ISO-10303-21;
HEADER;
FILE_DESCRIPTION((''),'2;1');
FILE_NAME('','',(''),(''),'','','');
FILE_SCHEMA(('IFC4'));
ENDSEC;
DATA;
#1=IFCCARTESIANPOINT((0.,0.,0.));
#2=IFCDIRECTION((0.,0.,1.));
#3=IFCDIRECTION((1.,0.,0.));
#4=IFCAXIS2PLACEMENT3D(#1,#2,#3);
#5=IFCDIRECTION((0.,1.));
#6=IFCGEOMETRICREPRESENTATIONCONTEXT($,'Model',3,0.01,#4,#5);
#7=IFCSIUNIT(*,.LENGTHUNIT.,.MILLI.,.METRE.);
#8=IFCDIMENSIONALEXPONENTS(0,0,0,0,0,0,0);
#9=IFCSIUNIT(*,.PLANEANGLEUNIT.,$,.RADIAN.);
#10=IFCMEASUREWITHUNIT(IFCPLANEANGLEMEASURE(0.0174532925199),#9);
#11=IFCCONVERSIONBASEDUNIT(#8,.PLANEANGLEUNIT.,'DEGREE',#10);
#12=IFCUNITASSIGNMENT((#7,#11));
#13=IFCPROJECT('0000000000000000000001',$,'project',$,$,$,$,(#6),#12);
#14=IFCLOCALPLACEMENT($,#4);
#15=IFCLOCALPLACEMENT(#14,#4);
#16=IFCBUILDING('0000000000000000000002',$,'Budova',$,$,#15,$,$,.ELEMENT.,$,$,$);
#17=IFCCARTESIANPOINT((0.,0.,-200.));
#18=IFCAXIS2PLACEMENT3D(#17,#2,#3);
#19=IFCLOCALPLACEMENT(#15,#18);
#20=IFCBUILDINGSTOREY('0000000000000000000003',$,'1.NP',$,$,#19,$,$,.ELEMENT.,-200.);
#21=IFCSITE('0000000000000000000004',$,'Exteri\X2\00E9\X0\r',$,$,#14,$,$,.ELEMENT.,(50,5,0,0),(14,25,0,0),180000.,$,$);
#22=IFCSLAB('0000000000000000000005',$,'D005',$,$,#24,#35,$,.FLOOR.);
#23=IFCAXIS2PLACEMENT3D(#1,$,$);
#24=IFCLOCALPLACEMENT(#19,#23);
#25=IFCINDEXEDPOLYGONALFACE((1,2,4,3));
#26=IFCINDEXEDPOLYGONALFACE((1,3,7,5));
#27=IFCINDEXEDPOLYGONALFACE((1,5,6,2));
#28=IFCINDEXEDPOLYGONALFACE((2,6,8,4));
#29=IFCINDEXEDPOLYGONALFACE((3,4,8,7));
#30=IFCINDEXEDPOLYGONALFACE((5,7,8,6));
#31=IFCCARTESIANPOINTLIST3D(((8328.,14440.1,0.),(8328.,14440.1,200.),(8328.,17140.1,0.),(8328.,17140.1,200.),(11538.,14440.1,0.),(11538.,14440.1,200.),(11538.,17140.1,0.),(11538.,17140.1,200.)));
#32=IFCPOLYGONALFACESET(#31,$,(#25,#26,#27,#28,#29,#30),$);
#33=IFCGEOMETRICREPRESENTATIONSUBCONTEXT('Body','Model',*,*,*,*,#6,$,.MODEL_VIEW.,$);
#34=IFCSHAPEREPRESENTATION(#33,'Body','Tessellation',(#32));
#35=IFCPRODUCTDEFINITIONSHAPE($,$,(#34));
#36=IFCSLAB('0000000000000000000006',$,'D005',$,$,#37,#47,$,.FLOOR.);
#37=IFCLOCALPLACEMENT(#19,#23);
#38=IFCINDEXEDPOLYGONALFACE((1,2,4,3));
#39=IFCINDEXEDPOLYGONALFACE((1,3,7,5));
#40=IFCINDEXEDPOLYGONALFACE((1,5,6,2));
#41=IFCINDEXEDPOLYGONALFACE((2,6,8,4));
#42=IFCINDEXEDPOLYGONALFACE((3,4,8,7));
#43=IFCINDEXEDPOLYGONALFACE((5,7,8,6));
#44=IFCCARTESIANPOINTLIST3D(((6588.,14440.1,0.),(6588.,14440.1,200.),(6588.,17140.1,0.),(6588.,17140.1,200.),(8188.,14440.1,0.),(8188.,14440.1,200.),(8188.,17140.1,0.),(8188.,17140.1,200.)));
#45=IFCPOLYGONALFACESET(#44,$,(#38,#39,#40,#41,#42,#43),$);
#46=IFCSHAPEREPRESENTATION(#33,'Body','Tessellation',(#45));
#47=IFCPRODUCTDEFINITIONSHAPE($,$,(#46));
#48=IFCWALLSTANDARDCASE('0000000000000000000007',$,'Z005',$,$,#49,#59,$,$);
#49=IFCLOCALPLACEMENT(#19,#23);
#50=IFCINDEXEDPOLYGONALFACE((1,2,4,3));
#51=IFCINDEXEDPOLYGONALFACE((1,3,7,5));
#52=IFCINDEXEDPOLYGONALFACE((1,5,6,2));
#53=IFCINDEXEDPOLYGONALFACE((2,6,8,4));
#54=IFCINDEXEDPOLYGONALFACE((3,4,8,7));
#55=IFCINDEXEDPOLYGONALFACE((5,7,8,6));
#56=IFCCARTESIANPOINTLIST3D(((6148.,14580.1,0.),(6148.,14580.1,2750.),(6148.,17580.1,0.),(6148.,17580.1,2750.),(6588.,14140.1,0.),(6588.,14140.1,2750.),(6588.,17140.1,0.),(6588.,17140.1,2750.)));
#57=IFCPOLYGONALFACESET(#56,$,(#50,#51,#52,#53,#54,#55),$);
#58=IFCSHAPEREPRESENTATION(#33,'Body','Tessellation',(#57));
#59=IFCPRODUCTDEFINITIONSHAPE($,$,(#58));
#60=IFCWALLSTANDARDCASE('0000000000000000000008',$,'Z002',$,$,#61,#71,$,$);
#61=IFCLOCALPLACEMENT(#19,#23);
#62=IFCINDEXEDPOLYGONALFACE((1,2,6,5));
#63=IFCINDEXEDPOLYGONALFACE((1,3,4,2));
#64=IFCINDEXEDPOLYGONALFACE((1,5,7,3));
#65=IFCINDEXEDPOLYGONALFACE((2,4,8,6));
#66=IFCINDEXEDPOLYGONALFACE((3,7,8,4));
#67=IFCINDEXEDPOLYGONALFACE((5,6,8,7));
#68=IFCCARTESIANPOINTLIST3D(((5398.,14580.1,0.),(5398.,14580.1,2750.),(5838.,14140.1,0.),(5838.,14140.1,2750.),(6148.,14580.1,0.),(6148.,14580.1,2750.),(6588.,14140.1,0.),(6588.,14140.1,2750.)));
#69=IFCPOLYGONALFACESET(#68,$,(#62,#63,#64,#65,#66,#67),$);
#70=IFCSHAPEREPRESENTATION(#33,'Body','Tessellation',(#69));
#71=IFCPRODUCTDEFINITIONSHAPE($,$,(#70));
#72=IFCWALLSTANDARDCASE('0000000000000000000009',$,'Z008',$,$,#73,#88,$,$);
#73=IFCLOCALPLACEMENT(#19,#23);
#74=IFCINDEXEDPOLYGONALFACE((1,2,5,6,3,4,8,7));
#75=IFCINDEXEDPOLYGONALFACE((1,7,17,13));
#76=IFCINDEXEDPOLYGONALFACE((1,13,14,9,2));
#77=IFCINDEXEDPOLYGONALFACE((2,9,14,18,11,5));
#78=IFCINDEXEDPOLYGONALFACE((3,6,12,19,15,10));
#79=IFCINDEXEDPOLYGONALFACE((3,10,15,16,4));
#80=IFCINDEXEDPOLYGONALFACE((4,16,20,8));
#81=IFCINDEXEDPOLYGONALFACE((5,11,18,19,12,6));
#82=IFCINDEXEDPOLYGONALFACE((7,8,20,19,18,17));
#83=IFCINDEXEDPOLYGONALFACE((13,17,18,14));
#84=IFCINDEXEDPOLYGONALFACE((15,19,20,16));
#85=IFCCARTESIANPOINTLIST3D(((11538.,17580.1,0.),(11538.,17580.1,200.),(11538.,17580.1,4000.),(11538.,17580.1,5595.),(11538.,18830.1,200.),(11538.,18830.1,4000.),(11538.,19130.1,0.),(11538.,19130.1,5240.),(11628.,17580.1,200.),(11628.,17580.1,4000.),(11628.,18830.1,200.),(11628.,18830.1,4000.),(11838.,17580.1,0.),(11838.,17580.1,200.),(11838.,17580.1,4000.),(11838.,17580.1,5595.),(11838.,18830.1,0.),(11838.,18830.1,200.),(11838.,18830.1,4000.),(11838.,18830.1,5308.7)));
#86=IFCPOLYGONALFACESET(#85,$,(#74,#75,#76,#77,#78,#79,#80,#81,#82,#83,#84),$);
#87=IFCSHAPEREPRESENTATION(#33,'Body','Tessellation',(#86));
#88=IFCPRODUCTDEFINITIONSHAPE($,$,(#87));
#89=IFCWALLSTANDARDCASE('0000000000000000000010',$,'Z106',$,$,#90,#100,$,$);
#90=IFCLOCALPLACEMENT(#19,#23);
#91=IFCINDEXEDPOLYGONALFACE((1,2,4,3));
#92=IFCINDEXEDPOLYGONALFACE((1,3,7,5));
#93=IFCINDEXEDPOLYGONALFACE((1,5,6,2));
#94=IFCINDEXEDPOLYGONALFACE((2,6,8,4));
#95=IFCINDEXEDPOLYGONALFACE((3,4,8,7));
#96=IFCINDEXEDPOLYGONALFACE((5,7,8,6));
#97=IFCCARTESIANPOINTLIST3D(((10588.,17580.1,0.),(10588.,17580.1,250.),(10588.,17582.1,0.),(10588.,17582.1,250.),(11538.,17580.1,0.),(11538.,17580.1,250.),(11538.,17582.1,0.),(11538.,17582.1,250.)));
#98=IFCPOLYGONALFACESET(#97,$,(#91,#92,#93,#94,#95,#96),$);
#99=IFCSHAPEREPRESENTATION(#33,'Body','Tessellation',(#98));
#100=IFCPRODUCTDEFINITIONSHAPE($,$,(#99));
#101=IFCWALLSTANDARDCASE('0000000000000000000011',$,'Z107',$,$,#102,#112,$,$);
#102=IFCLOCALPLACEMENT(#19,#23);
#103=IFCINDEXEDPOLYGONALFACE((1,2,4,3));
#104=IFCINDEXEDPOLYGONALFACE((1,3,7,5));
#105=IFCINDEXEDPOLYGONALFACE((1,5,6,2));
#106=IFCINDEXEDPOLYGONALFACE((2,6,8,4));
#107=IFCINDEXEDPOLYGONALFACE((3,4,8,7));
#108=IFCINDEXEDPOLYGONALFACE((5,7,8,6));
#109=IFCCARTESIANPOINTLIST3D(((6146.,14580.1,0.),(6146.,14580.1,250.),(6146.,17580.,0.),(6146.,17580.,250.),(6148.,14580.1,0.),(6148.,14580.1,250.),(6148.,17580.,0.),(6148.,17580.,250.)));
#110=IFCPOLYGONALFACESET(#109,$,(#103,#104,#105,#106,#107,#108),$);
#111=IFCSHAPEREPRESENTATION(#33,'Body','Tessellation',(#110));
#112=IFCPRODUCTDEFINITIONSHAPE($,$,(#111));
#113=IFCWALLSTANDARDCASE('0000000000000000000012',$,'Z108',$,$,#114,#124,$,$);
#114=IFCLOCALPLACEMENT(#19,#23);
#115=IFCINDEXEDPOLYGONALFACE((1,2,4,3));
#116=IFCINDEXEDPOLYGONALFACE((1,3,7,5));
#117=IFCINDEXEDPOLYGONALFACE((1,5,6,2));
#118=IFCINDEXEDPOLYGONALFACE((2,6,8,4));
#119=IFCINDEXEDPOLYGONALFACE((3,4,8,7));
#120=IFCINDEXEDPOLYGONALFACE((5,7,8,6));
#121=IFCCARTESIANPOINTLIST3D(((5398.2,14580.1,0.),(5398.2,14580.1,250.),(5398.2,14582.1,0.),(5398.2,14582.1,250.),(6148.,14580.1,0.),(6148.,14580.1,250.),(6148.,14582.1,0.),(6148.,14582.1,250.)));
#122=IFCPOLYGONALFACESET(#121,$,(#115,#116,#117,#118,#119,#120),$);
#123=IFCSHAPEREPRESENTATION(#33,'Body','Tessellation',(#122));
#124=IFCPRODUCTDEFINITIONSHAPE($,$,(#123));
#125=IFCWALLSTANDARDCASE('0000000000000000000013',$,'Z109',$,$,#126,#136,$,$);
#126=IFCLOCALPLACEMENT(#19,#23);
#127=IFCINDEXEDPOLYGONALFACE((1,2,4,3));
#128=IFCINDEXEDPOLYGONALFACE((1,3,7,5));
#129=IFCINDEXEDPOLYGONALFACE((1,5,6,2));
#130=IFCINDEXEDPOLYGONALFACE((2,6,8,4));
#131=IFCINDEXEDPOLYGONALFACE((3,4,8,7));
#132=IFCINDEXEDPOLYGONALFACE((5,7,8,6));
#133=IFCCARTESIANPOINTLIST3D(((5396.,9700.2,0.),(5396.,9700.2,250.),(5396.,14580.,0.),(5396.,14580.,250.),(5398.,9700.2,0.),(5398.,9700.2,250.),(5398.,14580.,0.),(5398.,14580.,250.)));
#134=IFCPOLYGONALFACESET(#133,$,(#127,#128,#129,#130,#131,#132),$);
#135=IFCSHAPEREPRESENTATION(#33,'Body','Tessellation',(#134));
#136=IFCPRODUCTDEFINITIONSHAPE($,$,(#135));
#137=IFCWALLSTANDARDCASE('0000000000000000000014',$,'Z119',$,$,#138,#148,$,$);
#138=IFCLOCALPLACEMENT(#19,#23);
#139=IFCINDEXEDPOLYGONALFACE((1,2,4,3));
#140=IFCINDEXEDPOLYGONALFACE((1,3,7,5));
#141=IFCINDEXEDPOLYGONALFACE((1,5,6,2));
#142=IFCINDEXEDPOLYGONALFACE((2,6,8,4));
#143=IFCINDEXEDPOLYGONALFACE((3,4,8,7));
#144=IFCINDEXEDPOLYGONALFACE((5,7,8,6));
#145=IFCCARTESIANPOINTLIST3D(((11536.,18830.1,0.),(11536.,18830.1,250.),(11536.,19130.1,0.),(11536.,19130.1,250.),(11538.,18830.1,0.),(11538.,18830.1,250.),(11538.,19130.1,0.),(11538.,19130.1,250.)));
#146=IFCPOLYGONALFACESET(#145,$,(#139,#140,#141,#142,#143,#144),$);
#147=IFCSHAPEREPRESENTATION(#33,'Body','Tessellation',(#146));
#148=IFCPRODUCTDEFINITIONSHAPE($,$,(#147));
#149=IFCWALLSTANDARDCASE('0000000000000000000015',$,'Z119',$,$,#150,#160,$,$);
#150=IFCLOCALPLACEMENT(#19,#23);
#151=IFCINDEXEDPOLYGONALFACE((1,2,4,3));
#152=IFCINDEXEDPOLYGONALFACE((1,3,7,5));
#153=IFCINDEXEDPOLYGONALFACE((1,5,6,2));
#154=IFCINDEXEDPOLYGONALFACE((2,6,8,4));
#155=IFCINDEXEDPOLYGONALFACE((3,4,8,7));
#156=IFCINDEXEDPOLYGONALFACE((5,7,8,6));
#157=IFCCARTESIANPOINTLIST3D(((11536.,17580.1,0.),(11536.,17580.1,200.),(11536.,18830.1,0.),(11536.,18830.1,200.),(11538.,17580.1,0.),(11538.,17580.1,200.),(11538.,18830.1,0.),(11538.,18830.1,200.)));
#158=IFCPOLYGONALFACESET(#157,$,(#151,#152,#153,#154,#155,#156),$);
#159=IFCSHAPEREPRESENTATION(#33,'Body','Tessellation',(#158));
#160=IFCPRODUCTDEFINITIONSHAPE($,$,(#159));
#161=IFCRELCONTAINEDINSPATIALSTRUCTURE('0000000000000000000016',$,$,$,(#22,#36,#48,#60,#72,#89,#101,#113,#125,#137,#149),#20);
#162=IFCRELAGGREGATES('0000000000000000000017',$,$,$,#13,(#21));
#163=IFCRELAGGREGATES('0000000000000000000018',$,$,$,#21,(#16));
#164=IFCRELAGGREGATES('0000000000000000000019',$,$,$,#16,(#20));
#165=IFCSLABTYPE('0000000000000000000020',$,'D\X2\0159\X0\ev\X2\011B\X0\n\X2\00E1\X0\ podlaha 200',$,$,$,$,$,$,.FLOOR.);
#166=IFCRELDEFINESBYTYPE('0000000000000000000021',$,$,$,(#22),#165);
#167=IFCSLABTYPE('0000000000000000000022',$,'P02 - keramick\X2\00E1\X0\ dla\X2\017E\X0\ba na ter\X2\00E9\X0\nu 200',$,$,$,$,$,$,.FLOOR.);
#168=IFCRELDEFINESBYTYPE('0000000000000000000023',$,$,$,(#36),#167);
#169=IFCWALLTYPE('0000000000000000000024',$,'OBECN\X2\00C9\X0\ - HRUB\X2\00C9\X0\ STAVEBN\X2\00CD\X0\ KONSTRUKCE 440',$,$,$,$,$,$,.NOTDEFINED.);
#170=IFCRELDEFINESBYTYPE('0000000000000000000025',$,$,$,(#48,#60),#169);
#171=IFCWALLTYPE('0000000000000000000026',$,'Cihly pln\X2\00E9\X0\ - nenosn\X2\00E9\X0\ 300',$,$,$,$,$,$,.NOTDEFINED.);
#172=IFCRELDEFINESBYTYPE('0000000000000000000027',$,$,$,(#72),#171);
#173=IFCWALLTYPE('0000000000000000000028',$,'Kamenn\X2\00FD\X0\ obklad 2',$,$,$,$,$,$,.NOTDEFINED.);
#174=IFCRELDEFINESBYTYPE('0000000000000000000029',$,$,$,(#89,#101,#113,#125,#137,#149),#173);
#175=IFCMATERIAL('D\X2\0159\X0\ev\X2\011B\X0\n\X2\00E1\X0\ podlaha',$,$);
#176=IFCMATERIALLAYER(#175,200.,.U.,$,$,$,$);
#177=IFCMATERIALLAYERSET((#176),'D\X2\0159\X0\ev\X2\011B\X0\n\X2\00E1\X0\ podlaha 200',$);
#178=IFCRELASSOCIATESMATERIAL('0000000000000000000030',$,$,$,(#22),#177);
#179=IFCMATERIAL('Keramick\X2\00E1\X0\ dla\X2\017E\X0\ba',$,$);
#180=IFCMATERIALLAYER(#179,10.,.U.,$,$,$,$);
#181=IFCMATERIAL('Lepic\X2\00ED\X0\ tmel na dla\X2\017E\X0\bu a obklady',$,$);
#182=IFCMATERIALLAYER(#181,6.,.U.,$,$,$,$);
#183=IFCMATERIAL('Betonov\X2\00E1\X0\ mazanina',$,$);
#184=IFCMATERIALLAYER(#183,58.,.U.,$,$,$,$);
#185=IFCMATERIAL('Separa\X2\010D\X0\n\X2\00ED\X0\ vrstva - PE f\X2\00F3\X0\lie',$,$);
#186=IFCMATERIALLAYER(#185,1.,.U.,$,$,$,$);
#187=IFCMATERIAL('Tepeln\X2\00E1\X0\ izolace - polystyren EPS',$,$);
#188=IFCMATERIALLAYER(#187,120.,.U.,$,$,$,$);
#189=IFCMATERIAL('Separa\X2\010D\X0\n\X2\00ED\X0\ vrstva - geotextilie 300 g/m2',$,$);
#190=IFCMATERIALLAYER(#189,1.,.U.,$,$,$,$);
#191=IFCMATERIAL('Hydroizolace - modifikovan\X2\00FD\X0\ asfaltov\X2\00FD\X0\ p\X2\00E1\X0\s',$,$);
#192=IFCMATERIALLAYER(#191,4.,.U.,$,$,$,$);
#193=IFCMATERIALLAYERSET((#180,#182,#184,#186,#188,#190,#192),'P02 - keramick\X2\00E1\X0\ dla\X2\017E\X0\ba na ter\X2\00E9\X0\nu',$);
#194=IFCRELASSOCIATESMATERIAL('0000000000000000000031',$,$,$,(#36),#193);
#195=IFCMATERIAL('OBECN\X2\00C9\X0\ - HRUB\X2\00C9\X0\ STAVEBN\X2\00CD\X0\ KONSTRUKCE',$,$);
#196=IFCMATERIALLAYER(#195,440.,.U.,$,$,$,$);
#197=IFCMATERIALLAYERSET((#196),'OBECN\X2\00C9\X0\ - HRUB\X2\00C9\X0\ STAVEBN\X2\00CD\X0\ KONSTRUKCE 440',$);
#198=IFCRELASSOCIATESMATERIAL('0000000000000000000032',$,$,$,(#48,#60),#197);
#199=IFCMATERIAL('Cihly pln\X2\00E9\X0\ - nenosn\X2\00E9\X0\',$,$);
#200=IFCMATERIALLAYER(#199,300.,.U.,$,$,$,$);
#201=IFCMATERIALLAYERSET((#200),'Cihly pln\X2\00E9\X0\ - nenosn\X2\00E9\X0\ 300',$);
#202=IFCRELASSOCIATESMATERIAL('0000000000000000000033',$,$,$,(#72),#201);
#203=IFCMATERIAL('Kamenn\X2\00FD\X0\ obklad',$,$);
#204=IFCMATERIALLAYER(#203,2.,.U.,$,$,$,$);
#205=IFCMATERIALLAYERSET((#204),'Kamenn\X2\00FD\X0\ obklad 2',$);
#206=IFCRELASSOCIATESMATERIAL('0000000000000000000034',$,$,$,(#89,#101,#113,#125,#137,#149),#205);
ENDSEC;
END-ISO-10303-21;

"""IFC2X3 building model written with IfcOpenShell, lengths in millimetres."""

from ifc_helpers import new_model, entity, si_unit, converted_unit, direction, frame, origin_with_axes, origin_2d_with_axis, place, context, subcontext, project, spatial, polyline, rectangle, outline, extrude, clip, halfspace, material, layer, layer_set, layer_usage, type_object, element, save


model = new_model("IFC2X3")

# Units and contexts
model_context = context("Model", 3, precision=0.01, world=origin_with_axes(), true_north=direction((0.0, 1.0)))
body_context = subcontext(model_context, "Body", "Model", "MODEL_VIEW")
ifc_project = project(units=[si_unit("LENGTHUNIT", "METRE", prefix="MILLI"), converted_unit("PLANEANGLEUNIT", "DEGREE", entity("IfcPlaneAngleMeasure", 0.0174532925199), si_unit("PLANEANGLEUNIT", "RADIAN"), dimensions=[0, 0, 0, 0, 0, 0, 0])], contexts=[model_context])

# Site, building, storey
site_placement = place(None, origin_with_axes())
site = spatial("IfcSite", under=ifc_project, at=site_placement, Name="Exteriér", CompositionType="ELEMENT", RefLatitude=(50, 5, 0, 0), RefLongitude=(14, 25, 0, 0), RefElevation=180000.0)
building_placement = place(site_placement, origin_with_axes())
building = spatial("IfcBuilding", under=site, at=building_placement, Name="Budova", CompositionType="ELEMENT")
storey_placement = place(building_placement, frame((0.0, 0.0, -200.0), z_axis=(0.0, 0.0, 1.0), x_axis=(1.0, 0.0, 0.0)))
storey = spatial("IfcBuildingStorey", under=building, at=storey_placement, Name="1.NP", CompositionType="ELEMENT", Elevation=-200.0)

# Slabs
ifc_material_1 = material(Name="Dřevěná podlaha")
ifc_layer_1 = layer(ifc_material_1, 200.0, ventilated="UNKNOWN")
ifc_layer_set_1 = layer_set([ifc_layer_1], Name="Dřevěná podlaha 200")
ifc_layer_usage_1 = layer_usage(ifc_layer_set_1, "AXIS3", "NEGATIVE", 200.0)
slab_type_1 = type_object("IfcSlabType", Name="Dřevěná podlaha 200", PredefinedType="FLOOR")
slab_1_placement = place(storey_placement, frame((8328.0, 14440.1, 0.0), z_axis=(0.0, 0.0, 1.0), x_axis=(1.0, 0.0, 0.0)))
element("IfcSlab", 1, at=slab_1_placement, inside=storey, type_object=slab_type_1, material=ifc_layer_usage_1, Name="D005", PredefinedType="FLOOR", context=body_context, shape_type="SweptSolid", body=[
    extrude(outline(polyline([(0.0, 0.0), (3210.0, 0.0), (3210.0, 2700.0), (0.0, 2700.0), (0.0, 0.0)])), origin_with_axes(), (0.0, 0.0, 1.0), 200.0),
])
ifc_material_2 = material(Name="Keramická dlažba")
ifc_layer_2 = layer(ifc_material_2, 10.0, ventilated="UNKNOWN")
ifc_material_3 = material(Name="Lepicí tmel na dlažbu a obklady")
ifc_layer_3 = layer(ifc_material_3, 6.0, ventilated="UNKNOWN")
ifc_material_4 = material(Name="Betonová mazanina")
ifc_layer_4 = layer(ifc_material_4, 58.0, ventilated="UNKNOWN")
ifc_material_5 = material(Name="Separační vrstva - PE fólie")
ifc_layer_5 = layer(ifc_material_5, 1.0, ventilated="UNKNOWN")
ifc_material_6 = material(Name="Tepelná izolace - polystyren EPS")
ifc_layer_6 = layer(ifc_material_6, 120.0, ventilated="UNKNOWN")
ifc_material_7 = material(Name="Separační vrstva - geotextilie 300 g/m2")
ifc_layer_7 = layer(ifc_material_7, 1.0, ventilated="UNKNOWN")
ifc_material_8 = material(Name="Hydroizolace - modifikovaný asfaltový pás")
ifc_layer_8 = layer(ifc_material_8, 4.0, ventilated="UNKNOWN")
ifc_layer_set_2 = layer_set([ifc_layer_2, ifc_layer_3, ifc_layer_4, ifc_layer_5, ifc_layer_6, ifc_layer_7, ifc_layer_8], Name="P02 - keramická dlažba na terénu")
ifc_layer_usage_2 = layer_usage(ifc_layer_set_2, "AXIS3", "NEGATIVE", 200.0)
slab_type_2 = type_object("IfcSlabType", Name="P02 - keramická dlažba na terénu 200", PredefinedType="FLOOR")
slab_2_placement = place(storey_placement, frame((6588.0, 14440.1, 0.0), z_axis=(0.0, 0.0, 1.0), x_axis=(1.0, 0.0, 0.0)))
element("IfcSlab", 2, at=slab_2_placement, inside=storey, type_object=slab_type_2, material=ifc_layer_usage_2, Name="D005", PredefinedType="FLOOR", context=body_context, shape_type="SweptSolid", body=[
    extrude(outline(polyline([(0.0, 0.0), (1600.0, 0.0), (1600.0, 2700.0), (0.0, 2700.0), (0.0, 0.0)])), origin_with_axes(), (0.0, 0.0, 1.0), 200.0),
])

# Walls
ifc_material_9 = material(Name="OBECNÉ - HRUBÉ STAVEBNÍ KONSTRUKCE")
ifc_layer_9 = layer(ifc_material_9, 440.0, ventilated="UNKNOWN")
ifc_layer_set_3 = layer_set([ifc_layer_9], Name="OBECNÉ - HRUBÉ STAVEBNÍ KONSTRUKCE 440")
ifc_layer_usage_3 = layer_usage(ifc_layer_set_3, "AXIS2", "NEGATIVE", 0.0)
wall_type_1 = type_object("IfcWallType", Name="OBECNÉ - HRUBÉ STAVEBNÍ KONSTRUKCE 440", PredefinedType="NOTDEFINED")
wall_1_placement = place(storey_placement, frame((6148.0, 14580.1, 0.0), z_axis=(0.0, 0.0, 1.0), x_axis=(0.0, 1.0, 0.0)))
element("IfcWallStandardCase", 3, at=wall_1_placement, inside=storey, type_object=wall_type_1, material=ifc_layer_usage_3, Name="Z005", context=body_context, shape_type="SweptSolid", body=[
    extrude(outline(polyline([(-440.0, -440.0), (2560.0, -440.0), (3000.0, 0.0), (0.0, 0.0), (-440.0, -440.0)])), origin_with_axes(), (0.0, 0.0, 1.0), 2750.0),
])
ifc_layer_usage_4 = layer_usage(ifc_layer_set_3, "AXIS2", "NEGATIVE", 440.0)
wall_2_placement = place(storey_placement, frame((6148.0, 14580.1, 0.0), z_axis=(0.0, 0.0, 1.0), x_axis=(-1.0, 0.0, 0.0)))
element("IfcWallStandardCase", 4, at=wall_2_placement, inside=storey, type_object=wall_type_1, material=ifc_layer_usage_4, Name="Z002", context=body_context, shape_type="SweptSolid", body=[
    extrude(outline(polyline([(0.0, 0.0), (750.0, 0.0), (310.0, 440.0), (-440.0, 440.0), (0.0, 0.0)])), origin_with_axes(), (0.0, 0.0, 1.0), 2750.0),
])

# Wall, opening
ifc_material_10 = material(Name="Cihly plné - nenosné")
ifc_layer_10 = layer(ifc_material_10, 300.0, ventilated="UNKNOWN")
ifc_layer_set_4 = layer_set([ifc_layer_10], Name="Cihly plné - nenosné 300")
ifc_layer_usage_5 = layer_usage(ifc_layer_set_4, "AXIS2", "POSITIVE", 0.0)
wall_type_2 = type_object("IfcWallType", Name="Cihly plné - nenosné 300", PredefinedType="NOTDEFINED")
wall_3_placement = place(storey_placement, frame((11538.0, 19130.1, 0.0), z_axis=(0.0, 0.0, 1.0), x_axis=(0.0, -1.0, 0.0)))
wall_3 = element("IfcWallStandardCase", 5, at=wall_3_placement, inside=storey, type_object=wall_type_2, material=ifc_layer_usage_5, Name="Z008", context=body_context, shape_type="Clipping", body=[
    clip(extrude(outline(polyline([(0.0, 0.0), (1550.0, 0.0), (1550.0, 300.0), (300.0, 300.0), (0.0, 0.0)])), origin_with_axes(), (0.0, 0.0, 1.0), 8000.0), halfspace(frame((-1140.3, 0.0, 4978.9), z_axis=(0.22325, 0.0, -0.974761), x_axis=(0.0, 1.0, 0.0)), True)),
])
opening_1_placement = place(wall_3_placement, frame((925.0, 0.0, 200.0), z_axis=(0.0, 0.0, 1.0), x_axis=(1.0, 0.0, 0.0)))
element("IfcOpeningElement", 6, at=opening_1_placement, cuts=wall_3, context=body_context, shape_type="SweptSolid", body=[
    extrude(rectangle(XDim=1250.0, YDim=3800.0, at=origin_2d_with_axis()), frame((0.0, 90.0, 1900.0), z_axis=(0.0, 1.0, 0.0), x_axis=(-1.0, 0.0, 0.0)), (0.0, 0.0, 1.0), 510.0),
    extrude(rectangle(XDim=1250.0, YDim=3800.0, at=origin_2d_with_axis()), frame((0.0, 90.0, 1900.0), z_axis=(0.0, -1.0, 0.0), x_axis=(-1.0, 0.0, 0.0)), (0.0, 0.0, 1.0), 390.0),
])

# Walls
ifc_material_11 = material(Name="Kamenný obklad")
ifc_layer_11 = layer(ifc_material_11, 2.0, ventilated="UNKNOWN")
ifc_layer_set_5 = layer_set([ifc_layer_11], Name="Kamenný obklad 2")
ifc_layer_usage_6 = layer_usage(ifc_layer_set_5, "AXIS2", "POSITIVE", -2.0)
wall_type_3 = type_object("IfcWallType", Name="Kamenný obklad 2", PredefinedType="NOTDEFINED")
wall_4_placement = place(storey_placement, frame((11538.0, 17580.1, 0.0), z_axis=(0.0, 0.0, 1.0), x_axis=(-1.0, 0.0, 0.0)))
element("IfcWallStandardCase", 7, at=wall_4_placement, inside=storey, type_object=wall_type_3, material=ifc_layer_usage_6, Name="Z106", context=body_context, shape_type="SweptSolid", body=[
    extrude(outline(polyline([(0.0, -2.0), (950.0, -2.0), (950.0, 0.0), (0.0, 0.0), (0.0, -2.0)])), origin_with_axes(), (0.0, 0.0, 1.0), 250.0),
])
ifc_layer_usage_7 = layer_usage(ifc_layer_set_5, "AXIS2", "POSITIVE", -2.0)
wall_5_placement = place(storey_placement, frame((6148.0, 17580.0, 0.0), z_axis=(0.0, 0.0, 1.0), x_axis=(0.0, -1.0, 0.0)))
element("IfcWallStandardCase", 8, at=wall_5_placement, inside=storey, type_object=wall_type_3, material=ifc_layer_usage_7, Name="Z107", context=body_context, shape_type="SweptSolid", body=[
    extrude(outline(polyline([(0.0, -2.0), (2999.8, -2.0), (2999.8, 0.0), (0.0, 0.0), (0.0, -2.0)])), origin_with_axes(), (0.0, 0.0, 1.0), 250.0),
])
ifc_layer_usage_8 = layer_usage(ifc_layer_set_5, "AXIS2", "POSITIVE", -2.0)
wall_6_placement = place(storey_placement, frame((6148.0, 14580.1, 0.0), z_axis=(0.0, 0.0, 1.0), x_axis=(-1.0, 0.0, 0.0)))
element("IfcWallStandardCase", 9, at=wall_6_placement, inside=storey, type_object=wall_type_3, material=ifc_layer_usage_8, Name="Z108", context=body_context, shape_type="SweptSolid", body=[
    extrude(outline(polyline([(0.0, -2.0), (749.9, -2.0), (749.9, 0.0), (0.0, 0.0), (0.0, -2.0)])), origin_with_axes(), (0.0, 0.0, 1.0), 250.0),
])
ifc_layer_usage_9 = layer_usage(ifc_layer_set_5, "AXIS2", "POSITIVE", -2.0)
wall_7_placement = place(storey_placement, frame((5398.0, 14580.0, 0.0), z_axis=(0.0, 0.0, 1.0), x_axis=(0.0, -1.0, 0.0)))
element("IfcWallStandardCase", 10, at=wall_7_placement, inside=storey, type_object=wall_type_3, material=ifc_layer_usage_9, Name="Z109", context=body_context, shape_type="SweptSolid", body=[
    extrude(outline(polyline([(0.0, -2.0), (4879.8, -2.0), (4879.8, 0.0), (0.0, 0.0), (0.0, -2.0)])), origin_with_axes(), (0.0, 0.0, 1.0), 250.0),
])
ifc_layer_usage_10 = layer_usage(ifc_layer_set_5, "AXIS2", "POSITIVE", -2.0)
wall_8_placement = place(storey_placement, frame((11538.0, 19130.1, 0.0), z_axis=(0.0, 0.0, 1.0), x_axis=(0.0, -1.0, 0.0)))
element("IfcWallStandardCase", 11, at=wall_8_placement, inside=storey, type_object=wall_type_3, material=ifc_layer_usage_10, Name="Z119", context=body_context, shape_type="SweptSolid", body=[
    extrude(outline(polyline([(0.0, -2.0), (299.9, -2.0), (299.9, 0.0), (0.0, 0.0), (0.0, -2.0)])), origin_with_axes(), (0.0, 0.0, 1.0), 250.0),
])
ifc_layer_usage_11 = layer_usage(ifc_layer_set_5, "AXIS2", "POSITIVE", -2.0)
wall_9_placement = place(storey_placement, frame((11538.0, 18830.1, 0.0), z_axis=(0.0, 0.0, 1.0), x_axis=(0.0, -1.0, 0.0)))
element("IfcWallStandardCase", 12, at=wall_9_placement, inside=storey, type_object=wall_type_3, material=ifc_layer_usage_11, Name="Z119", context=body_context, shape_type="SweptSolid", body=[
    extrude(outline(polyline([(0.0, -2.0), (1250.0, -2.0), (1250.0, 0.0), (0.0, 0.0), (0.0, -2.0)])), origin_with_axes(), (0.0, 0.0, 1.0), 200.0),
])

save(model, "model.ifc")
